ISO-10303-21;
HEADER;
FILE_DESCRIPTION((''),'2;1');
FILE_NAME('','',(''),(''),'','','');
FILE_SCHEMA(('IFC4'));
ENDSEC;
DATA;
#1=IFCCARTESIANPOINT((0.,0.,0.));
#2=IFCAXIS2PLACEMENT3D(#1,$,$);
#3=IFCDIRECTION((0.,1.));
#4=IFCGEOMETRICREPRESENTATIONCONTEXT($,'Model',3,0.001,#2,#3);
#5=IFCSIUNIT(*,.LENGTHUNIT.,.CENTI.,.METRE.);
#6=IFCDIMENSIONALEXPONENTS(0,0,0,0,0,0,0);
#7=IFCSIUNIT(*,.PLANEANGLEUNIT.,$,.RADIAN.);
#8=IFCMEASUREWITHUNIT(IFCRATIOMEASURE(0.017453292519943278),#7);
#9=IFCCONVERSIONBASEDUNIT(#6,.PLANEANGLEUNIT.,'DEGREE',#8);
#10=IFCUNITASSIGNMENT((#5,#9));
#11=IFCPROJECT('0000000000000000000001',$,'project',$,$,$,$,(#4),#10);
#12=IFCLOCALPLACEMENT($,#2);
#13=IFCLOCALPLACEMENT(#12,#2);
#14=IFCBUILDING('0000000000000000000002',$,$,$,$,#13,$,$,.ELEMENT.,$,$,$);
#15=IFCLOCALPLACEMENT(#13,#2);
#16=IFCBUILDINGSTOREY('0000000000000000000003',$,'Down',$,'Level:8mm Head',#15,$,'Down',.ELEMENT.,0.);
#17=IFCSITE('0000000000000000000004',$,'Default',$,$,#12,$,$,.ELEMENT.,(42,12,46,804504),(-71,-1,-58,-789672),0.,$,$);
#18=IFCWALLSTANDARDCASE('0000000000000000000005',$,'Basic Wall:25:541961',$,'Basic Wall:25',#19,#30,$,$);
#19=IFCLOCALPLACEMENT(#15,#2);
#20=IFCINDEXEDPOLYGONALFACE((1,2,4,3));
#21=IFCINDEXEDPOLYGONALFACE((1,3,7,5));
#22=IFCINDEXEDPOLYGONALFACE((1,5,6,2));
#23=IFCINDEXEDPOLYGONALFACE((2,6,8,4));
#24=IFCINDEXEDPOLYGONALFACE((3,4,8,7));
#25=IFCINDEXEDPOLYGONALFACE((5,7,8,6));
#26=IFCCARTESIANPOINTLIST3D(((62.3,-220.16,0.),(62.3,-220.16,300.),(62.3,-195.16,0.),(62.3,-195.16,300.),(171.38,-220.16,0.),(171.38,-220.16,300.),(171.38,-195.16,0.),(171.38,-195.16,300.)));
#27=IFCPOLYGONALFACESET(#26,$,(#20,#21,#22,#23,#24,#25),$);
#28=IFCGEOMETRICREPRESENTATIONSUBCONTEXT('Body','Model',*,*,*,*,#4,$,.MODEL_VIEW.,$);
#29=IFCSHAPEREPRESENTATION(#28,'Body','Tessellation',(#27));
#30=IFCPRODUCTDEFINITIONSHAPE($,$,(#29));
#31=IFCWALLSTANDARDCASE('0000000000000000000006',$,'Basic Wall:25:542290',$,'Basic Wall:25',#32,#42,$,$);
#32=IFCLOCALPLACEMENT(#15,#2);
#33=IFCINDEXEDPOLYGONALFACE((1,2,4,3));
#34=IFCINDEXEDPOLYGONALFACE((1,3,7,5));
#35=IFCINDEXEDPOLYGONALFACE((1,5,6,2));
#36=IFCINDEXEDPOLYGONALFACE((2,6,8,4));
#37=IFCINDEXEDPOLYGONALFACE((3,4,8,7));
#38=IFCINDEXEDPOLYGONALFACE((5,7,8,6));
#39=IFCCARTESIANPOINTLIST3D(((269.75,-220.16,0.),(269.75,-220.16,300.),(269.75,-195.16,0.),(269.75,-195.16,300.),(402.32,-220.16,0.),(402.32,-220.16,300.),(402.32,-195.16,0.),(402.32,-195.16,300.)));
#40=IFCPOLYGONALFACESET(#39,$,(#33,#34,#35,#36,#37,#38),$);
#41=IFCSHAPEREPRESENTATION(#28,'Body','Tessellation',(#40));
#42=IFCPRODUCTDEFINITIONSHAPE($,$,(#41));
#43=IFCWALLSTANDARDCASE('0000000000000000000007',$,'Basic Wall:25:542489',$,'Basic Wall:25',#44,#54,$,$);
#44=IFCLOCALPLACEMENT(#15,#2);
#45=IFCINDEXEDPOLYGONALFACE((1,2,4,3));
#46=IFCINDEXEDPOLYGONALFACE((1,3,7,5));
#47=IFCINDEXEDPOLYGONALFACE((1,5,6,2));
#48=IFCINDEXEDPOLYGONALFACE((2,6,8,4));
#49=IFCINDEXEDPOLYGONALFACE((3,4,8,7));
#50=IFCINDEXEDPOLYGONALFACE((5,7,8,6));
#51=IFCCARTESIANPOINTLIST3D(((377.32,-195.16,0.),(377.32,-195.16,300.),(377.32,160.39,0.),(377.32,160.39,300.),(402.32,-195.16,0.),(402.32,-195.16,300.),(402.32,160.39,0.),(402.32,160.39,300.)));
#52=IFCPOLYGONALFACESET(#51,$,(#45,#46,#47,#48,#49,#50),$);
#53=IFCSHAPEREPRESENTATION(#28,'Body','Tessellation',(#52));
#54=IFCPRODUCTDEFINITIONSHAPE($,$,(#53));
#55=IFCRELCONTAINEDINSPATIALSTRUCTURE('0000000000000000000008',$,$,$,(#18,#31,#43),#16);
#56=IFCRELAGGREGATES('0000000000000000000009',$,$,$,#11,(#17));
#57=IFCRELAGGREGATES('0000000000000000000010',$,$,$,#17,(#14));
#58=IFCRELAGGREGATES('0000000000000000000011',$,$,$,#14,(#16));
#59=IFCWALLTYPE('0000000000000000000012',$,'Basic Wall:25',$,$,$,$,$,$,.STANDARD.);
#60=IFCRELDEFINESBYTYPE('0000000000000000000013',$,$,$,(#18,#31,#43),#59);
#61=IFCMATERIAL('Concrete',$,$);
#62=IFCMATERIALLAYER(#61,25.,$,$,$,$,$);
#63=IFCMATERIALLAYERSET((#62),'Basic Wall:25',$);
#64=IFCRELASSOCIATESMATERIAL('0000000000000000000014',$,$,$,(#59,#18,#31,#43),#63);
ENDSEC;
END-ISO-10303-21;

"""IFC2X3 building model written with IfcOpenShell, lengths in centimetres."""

from ifc_helpers import new_model, entity, si_unit, converted_unit, direction, frame, frame_2d, origin, place, context, subcontext, project, spatial, rectangle, extrude, material, layer, layer_set, layer_usage, type_object, element, save


model = new_model("IFC2X3")

# Units and contexts
model_context = context("Model", 3, precision=0.001, world=origin(), true_north=direction((0.0, 1.0)))
body_context = subcontext(model_context, "Body", "Model", "MODEL_VIEW")
ifc_project = project(units=[si_unit("LENGTHUNIT", "METRE", prefix="CENTI"), converted_unit("PLANEANGLEUNIT", "DEGREE", entity("IfcRatioMeasure", 0.017453292519943278), si_unit("PLANEANGLEUNIT", "RADIAN"), dimensions=[0, 0, 0, 0, 0, 0, 0])], contexts=[model_context])

# Site, building, storey
site_placement = place(None, origin())
site = spatial("IfcSite", under=ifc_project, at=site_placement, Name="Default", CompositionType="ELEMENT", RefLatitude=(42, 12, 46, 804504), RefLongitude=(-71, -1, -58, -789672), RefElevation=0.0)
building_placement = place(site_placement, origin())
building = spatial("IfcBuilding", under=site, at=building_placement, CompositionType="ELEMENT")
storey_placement = place(building_placement, origin())
storey = spatial("IfcBuildingStorey", under=building, at=storey_placement, Name="Down", ObjectType="Level:8mm Head", LongName="Down", CompositionType="ELEMENT", Elevation=0.0)

# Shared definitions
ifc_material = material(Name="Concrete")

# Walls
ifc_layer_1 = layer(ifc_material, 25.0)
ifc_layer_set_1 = layer_set([ifc_layer_1], Name="Basic Wall:25")
ifc_layer_usage_1 = layer_usage(ifc_layer_set_1, "AXIS2", "POSITIVE", -12.5)
wall_type_1 = type_object("IfcWallType", Name="Basic Wall:25", PredefinedType="STANDARD", material=ifc_layer_set_1)
wall_1_placement = place(storey_placement, frame((62.3, -207.66, 0.0)))
element("IfcWallStandardCase", 1, at=wall_1_placement, inside=storey, type_object=wall_type_1, material=ifc_layer_usage_1, Name="Basic Wall:25:541961", ObjectType="Basic Wall:25", context=body_context, shape_type="SweptSolid", body=[
    extrude(rectangle(XDim=109.08, YDim=25.0, at=frame_2d((54.54, 0.0), x_axis=(-1.0, 0.0))), origin(), (0.0, 0.0, 1.0), 300.0),
])
ifc_layer_usage_2 = layer_usage(ifc_layer_set_1, "AXIS2", "NEGATIVE", 12.5)
wall_2_placement = place(storey_placement, frame((269.75, -207.66, 0.0)))
element("IfcWallStandardCase", 2, at=wall_2_placement, inside=storey, type_object=wall_type_1, material=ifc_layer_usage_2, Name="Basic Wall:25:542290", ObjectType="Basic Wall:25", context=body_context, shape_type="SweptSolid", body=[
    extrude(rectangle(XDim=132.57, YDim=25.0, at=frame_2d((66.28, 0.0), x_axis=(-1.0, 0.0))), origin(), (0.0, 0.0, 1.0), 300.0),
])
ifc_layer_usage_3 = layer_usage(ifc_layer_set_1, "AXIS2", "POSITIVE", -12.5)
wall_3_placement = place(storey_placement, frame((389.82, -195.16, 0.0), z_axis=(0.0, 0.0, 1.0), x_axis=(0.0, 1.0, 0.0)))
element("IfcWallStandardCase", 3, at=wall_3_placement, inside=storey, type_object=wall_type_1, material=ifc_layer_usage_3, Name="Basic Wall:25:542489", ObjectType="Basic Wall:25", context=body_context, shape_type="SweptSolid", body=[
    extrude(rectangle(XDim=355.55, YDim=25.0, at=frame_2d((177.77, 0.0), x_axis=(-1.0, 0.0))), origin(), (0.0, 0.0, 1.0), 300.0),
])

save(model, "model.ifc")
